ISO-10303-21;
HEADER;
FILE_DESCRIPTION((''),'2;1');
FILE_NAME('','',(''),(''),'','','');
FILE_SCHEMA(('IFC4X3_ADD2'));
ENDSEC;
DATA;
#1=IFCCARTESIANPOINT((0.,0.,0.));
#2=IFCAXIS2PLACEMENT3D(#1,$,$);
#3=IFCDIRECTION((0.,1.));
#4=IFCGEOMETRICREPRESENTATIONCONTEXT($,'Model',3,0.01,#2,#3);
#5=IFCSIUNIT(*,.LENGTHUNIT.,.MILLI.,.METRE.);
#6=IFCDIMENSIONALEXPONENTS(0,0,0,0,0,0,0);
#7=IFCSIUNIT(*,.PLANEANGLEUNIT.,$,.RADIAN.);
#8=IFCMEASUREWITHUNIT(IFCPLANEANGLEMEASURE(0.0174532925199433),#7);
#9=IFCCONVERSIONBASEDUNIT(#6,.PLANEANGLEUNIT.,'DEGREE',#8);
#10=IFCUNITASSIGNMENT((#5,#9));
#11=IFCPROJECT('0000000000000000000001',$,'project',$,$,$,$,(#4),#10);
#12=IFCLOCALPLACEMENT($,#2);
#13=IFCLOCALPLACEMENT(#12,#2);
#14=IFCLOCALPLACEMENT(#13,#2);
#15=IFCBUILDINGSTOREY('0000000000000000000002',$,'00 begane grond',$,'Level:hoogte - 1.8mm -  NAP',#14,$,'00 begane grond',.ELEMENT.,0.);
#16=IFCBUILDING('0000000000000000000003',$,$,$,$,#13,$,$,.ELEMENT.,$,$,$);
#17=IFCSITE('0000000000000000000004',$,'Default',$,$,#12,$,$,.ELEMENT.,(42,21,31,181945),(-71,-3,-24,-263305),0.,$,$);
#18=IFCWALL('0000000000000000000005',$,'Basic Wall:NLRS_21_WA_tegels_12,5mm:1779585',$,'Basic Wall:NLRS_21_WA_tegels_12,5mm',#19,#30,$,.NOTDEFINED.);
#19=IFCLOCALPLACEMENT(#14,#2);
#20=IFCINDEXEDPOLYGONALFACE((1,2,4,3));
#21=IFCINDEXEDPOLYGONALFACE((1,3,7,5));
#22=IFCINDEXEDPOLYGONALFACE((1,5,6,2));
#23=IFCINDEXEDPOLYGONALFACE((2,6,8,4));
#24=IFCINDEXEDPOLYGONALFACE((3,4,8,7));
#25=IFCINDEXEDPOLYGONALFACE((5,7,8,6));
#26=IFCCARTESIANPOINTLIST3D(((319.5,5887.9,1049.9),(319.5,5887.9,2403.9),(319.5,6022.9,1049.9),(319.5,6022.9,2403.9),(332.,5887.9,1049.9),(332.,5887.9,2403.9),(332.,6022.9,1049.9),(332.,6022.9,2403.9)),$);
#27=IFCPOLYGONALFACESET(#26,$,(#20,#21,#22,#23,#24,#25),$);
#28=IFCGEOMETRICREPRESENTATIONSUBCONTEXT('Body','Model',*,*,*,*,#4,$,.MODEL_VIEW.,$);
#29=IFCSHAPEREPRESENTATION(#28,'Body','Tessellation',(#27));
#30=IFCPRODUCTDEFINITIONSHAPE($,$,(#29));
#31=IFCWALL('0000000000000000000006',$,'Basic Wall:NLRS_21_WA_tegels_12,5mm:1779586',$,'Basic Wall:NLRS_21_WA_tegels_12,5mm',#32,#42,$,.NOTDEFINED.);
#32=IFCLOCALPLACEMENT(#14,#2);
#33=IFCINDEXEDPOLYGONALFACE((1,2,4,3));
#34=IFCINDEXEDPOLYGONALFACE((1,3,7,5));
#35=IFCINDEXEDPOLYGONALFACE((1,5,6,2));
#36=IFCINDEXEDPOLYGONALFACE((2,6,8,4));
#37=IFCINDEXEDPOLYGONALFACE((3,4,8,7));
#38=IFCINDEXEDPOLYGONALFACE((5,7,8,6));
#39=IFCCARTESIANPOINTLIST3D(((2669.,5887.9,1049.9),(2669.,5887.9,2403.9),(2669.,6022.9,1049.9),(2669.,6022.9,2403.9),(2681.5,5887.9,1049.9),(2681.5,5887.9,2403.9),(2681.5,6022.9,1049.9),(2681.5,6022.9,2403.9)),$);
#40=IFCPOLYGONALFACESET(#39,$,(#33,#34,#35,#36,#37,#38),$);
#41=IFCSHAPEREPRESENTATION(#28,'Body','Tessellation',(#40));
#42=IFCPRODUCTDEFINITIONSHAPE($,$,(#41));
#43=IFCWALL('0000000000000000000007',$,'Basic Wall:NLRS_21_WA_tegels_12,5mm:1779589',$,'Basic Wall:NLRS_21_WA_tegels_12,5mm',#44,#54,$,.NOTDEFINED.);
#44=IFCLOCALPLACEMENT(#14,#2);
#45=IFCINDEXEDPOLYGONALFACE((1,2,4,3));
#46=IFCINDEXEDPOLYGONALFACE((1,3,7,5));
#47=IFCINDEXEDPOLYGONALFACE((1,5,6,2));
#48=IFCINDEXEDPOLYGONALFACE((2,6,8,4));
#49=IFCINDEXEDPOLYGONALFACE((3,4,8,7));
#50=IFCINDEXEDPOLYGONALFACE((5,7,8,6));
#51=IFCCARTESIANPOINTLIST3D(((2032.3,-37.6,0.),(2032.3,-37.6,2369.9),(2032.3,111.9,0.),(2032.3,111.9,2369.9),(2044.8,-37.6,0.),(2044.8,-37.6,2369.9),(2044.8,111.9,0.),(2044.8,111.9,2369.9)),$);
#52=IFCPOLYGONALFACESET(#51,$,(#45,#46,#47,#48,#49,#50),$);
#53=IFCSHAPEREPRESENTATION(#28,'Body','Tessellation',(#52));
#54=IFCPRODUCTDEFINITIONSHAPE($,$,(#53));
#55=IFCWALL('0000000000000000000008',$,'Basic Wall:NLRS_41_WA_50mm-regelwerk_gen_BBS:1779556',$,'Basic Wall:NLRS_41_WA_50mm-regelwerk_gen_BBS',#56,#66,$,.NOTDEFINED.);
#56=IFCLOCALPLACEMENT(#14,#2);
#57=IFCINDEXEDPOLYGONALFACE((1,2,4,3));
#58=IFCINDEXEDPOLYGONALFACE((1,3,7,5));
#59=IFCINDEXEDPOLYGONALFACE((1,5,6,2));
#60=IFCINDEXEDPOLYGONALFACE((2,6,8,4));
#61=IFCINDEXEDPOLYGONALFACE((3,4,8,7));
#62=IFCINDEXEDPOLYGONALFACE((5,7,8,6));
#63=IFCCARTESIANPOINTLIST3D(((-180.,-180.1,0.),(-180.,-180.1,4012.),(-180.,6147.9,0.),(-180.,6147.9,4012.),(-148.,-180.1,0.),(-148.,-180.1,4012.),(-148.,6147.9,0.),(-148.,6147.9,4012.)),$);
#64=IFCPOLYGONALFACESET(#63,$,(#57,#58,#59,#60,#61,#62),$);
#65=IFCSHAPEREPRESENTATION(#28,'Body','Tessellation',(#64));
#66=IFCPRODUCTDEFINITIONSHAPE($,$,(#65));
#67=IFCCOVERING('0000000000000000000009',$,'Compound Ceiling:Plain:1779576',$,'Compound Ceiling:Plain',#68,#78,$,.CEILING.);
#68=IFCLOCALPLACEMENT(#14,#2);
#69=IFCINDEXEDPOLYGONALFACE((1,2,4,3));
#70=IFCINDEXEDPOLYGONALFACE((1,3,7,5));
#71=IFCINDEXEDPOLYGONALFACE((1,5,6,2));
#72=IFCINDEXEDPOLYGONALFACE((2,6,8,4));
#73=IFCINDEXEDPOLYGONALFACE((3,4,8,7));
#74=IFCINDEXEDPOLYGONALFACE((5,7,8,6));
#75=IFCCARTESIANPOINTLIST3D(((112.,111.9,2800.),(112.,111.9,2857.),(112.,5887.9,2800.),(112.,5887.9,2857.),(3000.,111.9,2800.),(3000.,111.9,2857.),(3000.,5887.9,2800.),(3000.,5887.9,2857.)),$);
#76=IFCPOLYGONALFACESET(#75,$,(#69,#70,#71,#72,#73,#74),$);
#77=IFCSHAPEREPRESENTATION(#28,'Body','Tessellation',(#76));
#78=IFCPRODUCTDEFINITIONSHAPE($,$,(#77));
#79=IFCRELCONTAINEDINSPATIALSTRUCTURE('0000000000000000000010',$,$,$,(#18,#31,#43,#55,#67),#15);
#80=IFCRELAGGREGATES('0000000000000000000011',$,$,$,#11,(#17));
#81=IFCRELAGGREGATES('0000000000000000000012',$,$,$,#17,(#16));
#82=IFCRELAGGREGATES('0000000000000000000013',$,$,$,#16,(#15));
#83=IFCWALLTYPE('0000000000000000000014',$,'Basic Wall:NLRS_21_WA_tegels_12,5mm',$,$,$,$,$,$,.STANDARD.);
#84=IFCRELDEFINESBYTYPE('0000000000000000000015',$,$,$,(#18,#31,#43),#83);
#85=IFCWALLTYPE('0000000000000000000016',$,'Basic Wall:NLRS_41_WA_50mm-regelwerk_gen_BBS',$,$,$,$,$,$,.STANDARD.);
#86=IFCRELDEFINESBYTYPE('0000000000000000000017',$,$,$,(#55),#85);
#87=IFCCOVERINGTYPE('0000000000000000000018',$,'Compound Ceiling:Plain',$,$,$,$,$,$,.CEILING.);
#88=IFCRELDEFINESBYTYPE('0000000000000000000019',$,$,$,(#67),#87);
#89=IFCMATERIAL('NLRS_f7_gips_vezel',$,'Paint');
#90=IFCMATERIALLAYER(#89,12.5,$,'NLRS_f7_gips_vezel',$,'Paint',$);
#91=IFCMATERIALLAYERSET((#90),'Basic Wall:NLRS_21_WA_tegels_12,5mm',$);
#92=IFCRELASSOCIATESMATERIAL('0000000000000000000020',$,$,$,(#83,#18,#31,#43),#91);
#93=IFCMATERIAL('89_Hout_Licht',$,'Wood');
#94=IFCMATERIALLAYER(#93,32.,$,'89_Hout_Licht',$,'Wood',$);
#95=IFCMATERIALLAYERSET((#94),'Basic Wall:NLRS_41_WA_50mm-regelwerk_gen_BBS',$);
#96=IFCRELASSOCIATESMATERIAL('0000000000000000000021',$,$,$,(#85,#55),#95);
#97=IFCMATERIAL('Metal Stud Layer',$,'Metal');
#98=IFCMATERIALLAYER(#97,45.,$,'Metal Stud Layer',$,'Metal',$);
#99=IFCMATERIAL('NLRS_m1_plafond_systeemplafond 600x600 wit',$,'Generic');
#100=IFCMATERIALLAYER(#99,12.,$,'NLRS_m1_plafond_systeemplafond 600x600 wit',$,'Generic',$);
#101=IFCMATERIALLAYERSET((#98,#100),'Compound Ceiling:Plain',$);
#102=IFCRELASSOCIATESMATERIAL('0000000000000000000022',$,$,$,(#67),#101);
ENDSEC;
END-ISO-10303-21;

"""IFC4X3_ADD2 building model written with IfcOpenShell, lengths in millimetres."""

from ifc_helpers import new_model, entity, si_unit, converted_unit, direction, frame, frame_2d, origin, place, context, subcontext, project, spatial, rectangle, extrude, material, layer, layer_set, layer_usage, type_object, element, save


model = new_model("IFC4X3_ADD2")

# Units and contexts
model_context = context("Model", 3, precision=0.01, world=origin(), true_north=direction((0.0, 1.0)))
body_context = subcontext(model_context, "Body", "Model", "MODEL_VIEW")
ifc_project = project(units=[si_unit("LENGTHUNIT", "METRE", prefix="MILLI"), converted_unit("PLANEANGLEUNIT", "DEGREE", entity("IfcPlaneAngleMeasure", 0.0174532925199433), si_unit("PLANEANGLEUNIT", "RADIAN"), dimensions=[0, 0, 0, 0, 0, 0, 0])], contexts=[model_context])

# Site, building, storey
site_placement = place(None, origin())
site = spatial("IfcSite", under=ifc_project, at=site_placement, Name="Default", CompositionType="ELEMENT", RefLatitude=(42, 21, 31, 181945), RefLongitude=(-71, -3, -24, -263305), RefElevation=0.0)
building_placement = place(site_placement, origin())
building = spatial("IfcBuilding", under=site, at=building_placement, CompositionType="ELEMENT")
storey_placement = place(building_placement, origin())
storey = spatial("IfcBuildingStorey", under=building, at=storey_placement, Name="00 begane grond", ObjectType="Level:hoogte - 1.8mm -  NAP", LongName="00 begane grond", CompositionType="ELEMENT", Elevation=0.0)

# Walls
ifc_material_1 = material(Name="NLRS_f7_gips_vezel", Category="Paint")
ifc_layer_1 = layer(ifc_material_1, 12.5, Name="NLRS_f7_gips_vezel", Category="Paint")
ifc_layer_set_1 = layer_set([ifc_layer_1], Name="Basic Wall:NLRS_21_WA_tegels_12,5mm")
wall_type_1 = type_object("IfcWallType", Name="Basic Wall:NLRS_21_WA_tegels_12,5mm", PredefinedType="STANDARD", material=ifc_layer_set_1)
ifc_layer_usage_1 = layer_usage(ifc_layer_set_1, "AXIS2", "POSITIVE", -6.2)
wall_1_placement = place(storey_placement, frame((325.7, 5887.9, 1049.9), z_axis=(0.0, 0.0, 1.0), x_axis=(0.0, 1.0, 0.0)))
element("IfcWall", 1, at=wall_1_placement, inside=storey, type_object=wall_type_1, material=ifc_layer_usage_1, Name="Basic Wall:NLRS_21_WA_tegels_12,5mm:1779585", ObjectType="Basic Wall:NLRS_21_WA_tegels_12,5mm", PredefinedType="NOTDEFINED", context=body_context, shape_type="SweptSolid", body=[
    extrude(rectangle(XDim=135.0, YDim=12.5, at=frame_2d((67.5, 0.0), x_axis=(-1.0, 0.0))), origin(), (0.0, 0.0, 1.0), 1354.0),
])
ifc_layer_usage_2 = layer_usage(ifc_layer_set_1, "AXIS2", "NEGATIVE", 6.2)
wall_2_placement = place(storey_placement, frame((2675.2, 5887.9, 1049.9), z_axis=(0.0, 0.0, 1.0), x_axis=(0.0, 1.0, 0.0)))
element("IfcWall", 2, at=wall_2_placement, inside=storey, type_object=wall_type_1, material=ifc_layer_usage_2, Name="Basic Wall:NLRS_21_WA_tegels_12,5mm:1779586", ObjectType="Basic Wall:NLRS_21_WA_tegels_12,5mm", PredefinedType="NOTDEFINED", context=body_context, shape_type="SweptSolid", body=[
    extrude(rectangle(XDim=135.0, YDim=12.5, at=frame_2d((67.5, 0.0), x_axis=(-1.0, 0.0))), origin(), (0.0, 0.0, 1.0), 1354.0),
])
ifc_layer_usage_3 = layer_usage(ifc_layer_set_1, "AXIS2", "POSITIVE", -6.2)
wall_3_placement = place(storey_placement, frame((2038.6, 111.9, 0.0), z_axis=(0.0, 0.0, 1.0), x_axis=(0.0, -1.0, 0.0)))
element("IfcWall", 3, at=wall_3_placement, inside=storey, type_object=wall_type_1, material=ifc_layer_usage_3, Name="Basic Wall:NLRS_21_WA_tegels_12,5mm:1779589", ObjectType="Basic Wall:NLRS_21_WA_tegels_12,5mm", PredefinedType="NOTDEFINED", context=body_context, shape_type="SweptSolid", body=[
    extrude(rectangle(XDim=149.5, YDim=12.5, at=frame_2d((74.7, 0.0), x_axis=(-1.0, 0.0))), origin(), (0.0, 0.0, 1.0), 2369.9),
])
ifc_material_2 = material(Name="89_Hout_Licht", Category="Wood")
ifc_layer_2 = layer(ifc_material_2, 32.0, Name="89_Hout_Licht", Category="Wood")
ifc_layer_set_2 = layer_set([ifc_layer_2], Name="Basic Wall:NLRS_41_WA_50mm-regelwerk_gen_BBS")
ifc_layer_usage_4 = layer_usage(ifc_layer_set_2, "AXIS2", "POSITIVE", -16.0)
wall_type_2 = type_object("IfcWallType", Name="Basic Wall:NLRS_41_WA_50mm-regelwerk_gen_BBS", PredefinedType="STANDARD", material=ifc_layer_set_2)
wall_4_placement = place(storey_placement, frame((-164.0, 6147.9, 0.0), z_axis=(0.0, 0.0, 1.0), x_axis=(0.0, -1.0, 0.0)))
element("IfcWall", 4, at=wall_4_placement, inside=storey, type_object=wall_type_2, material=ifc_layer_usage_4, Name="Basic Wall:NLRS_41_WA_50mm-regelwerk_gen_BBS:1779556", ObjectType="Basic Wall:NLRS_41_WA_50mm-regelwerk_gen_BBS", PredefinedType="NOTDEFINED", context=body_context, shape_type="SweptSolid", body=[
    extrude(rectangle(XDim=6328.0, YDim=32.0, at=frame_2d((3164.0, 0.0), x_axis=(-1.0, 0.0))), origin(), (0.0, 0.0, 1.0), 4012.0),
])

# Covering
ifc_material_3 = material(Name="Metal Stud Layer", Category="Metal")
ifc_layer_3 = layer(ifc_material_3, 45.0, Name="Metal Stud Layer", Category="Metal")
ifc_material_4 = material(Name="NLRS_m1_plafond_systeemplafond 600x600 wit", Category="Generic")
ifc_layer_4 = layer(ifc_material_4, 12.0, Name="NLRS_m1_plafond_systeemplafond 600x600 wit", Category="Generic")
ifc_layer_set_3 = layer_set([ifc_layer_3, ifc_layer_4], Name="Compound Ceiling:Plain")
ifc_layer_usage_5 = layer_usage(ifc_layer_set_3, "AXIS3", "NEGATIVE", 57.0)
covering_type = type_object("IfcCoveringType", Name="Compound Ceiling:Plain", PredefinedType="CEILING")
covering_placement = place(storey_placement, frame((112.0, 111.9, 2800.0)))
element("IfcCovering", 5, at=covering_placement, inside=storey, type_object=covering_type, material=ifc_layer_usage_5, Name="Compound Ceiling:Plain:1779576", ObjectType="Compound Ceiling:Plain", PredefinedType="CEILING", context=body_context, shape_type="SweptSolid", body=[
    extrude(rectangle(XDim=2888.0, YDim=5776.0, at=frame_2d((0.0, 0.0), x_axis=(1.0, 0.0))), frame((1444.0, 2888.0, 0.0), z_axis=(0.0, 0.0, 1.0), x_axis=(-1.0, 0.0, 0.0)), (0.0, 0.0, 1.0), 57.0),
])

save(model, "model.ifc")
